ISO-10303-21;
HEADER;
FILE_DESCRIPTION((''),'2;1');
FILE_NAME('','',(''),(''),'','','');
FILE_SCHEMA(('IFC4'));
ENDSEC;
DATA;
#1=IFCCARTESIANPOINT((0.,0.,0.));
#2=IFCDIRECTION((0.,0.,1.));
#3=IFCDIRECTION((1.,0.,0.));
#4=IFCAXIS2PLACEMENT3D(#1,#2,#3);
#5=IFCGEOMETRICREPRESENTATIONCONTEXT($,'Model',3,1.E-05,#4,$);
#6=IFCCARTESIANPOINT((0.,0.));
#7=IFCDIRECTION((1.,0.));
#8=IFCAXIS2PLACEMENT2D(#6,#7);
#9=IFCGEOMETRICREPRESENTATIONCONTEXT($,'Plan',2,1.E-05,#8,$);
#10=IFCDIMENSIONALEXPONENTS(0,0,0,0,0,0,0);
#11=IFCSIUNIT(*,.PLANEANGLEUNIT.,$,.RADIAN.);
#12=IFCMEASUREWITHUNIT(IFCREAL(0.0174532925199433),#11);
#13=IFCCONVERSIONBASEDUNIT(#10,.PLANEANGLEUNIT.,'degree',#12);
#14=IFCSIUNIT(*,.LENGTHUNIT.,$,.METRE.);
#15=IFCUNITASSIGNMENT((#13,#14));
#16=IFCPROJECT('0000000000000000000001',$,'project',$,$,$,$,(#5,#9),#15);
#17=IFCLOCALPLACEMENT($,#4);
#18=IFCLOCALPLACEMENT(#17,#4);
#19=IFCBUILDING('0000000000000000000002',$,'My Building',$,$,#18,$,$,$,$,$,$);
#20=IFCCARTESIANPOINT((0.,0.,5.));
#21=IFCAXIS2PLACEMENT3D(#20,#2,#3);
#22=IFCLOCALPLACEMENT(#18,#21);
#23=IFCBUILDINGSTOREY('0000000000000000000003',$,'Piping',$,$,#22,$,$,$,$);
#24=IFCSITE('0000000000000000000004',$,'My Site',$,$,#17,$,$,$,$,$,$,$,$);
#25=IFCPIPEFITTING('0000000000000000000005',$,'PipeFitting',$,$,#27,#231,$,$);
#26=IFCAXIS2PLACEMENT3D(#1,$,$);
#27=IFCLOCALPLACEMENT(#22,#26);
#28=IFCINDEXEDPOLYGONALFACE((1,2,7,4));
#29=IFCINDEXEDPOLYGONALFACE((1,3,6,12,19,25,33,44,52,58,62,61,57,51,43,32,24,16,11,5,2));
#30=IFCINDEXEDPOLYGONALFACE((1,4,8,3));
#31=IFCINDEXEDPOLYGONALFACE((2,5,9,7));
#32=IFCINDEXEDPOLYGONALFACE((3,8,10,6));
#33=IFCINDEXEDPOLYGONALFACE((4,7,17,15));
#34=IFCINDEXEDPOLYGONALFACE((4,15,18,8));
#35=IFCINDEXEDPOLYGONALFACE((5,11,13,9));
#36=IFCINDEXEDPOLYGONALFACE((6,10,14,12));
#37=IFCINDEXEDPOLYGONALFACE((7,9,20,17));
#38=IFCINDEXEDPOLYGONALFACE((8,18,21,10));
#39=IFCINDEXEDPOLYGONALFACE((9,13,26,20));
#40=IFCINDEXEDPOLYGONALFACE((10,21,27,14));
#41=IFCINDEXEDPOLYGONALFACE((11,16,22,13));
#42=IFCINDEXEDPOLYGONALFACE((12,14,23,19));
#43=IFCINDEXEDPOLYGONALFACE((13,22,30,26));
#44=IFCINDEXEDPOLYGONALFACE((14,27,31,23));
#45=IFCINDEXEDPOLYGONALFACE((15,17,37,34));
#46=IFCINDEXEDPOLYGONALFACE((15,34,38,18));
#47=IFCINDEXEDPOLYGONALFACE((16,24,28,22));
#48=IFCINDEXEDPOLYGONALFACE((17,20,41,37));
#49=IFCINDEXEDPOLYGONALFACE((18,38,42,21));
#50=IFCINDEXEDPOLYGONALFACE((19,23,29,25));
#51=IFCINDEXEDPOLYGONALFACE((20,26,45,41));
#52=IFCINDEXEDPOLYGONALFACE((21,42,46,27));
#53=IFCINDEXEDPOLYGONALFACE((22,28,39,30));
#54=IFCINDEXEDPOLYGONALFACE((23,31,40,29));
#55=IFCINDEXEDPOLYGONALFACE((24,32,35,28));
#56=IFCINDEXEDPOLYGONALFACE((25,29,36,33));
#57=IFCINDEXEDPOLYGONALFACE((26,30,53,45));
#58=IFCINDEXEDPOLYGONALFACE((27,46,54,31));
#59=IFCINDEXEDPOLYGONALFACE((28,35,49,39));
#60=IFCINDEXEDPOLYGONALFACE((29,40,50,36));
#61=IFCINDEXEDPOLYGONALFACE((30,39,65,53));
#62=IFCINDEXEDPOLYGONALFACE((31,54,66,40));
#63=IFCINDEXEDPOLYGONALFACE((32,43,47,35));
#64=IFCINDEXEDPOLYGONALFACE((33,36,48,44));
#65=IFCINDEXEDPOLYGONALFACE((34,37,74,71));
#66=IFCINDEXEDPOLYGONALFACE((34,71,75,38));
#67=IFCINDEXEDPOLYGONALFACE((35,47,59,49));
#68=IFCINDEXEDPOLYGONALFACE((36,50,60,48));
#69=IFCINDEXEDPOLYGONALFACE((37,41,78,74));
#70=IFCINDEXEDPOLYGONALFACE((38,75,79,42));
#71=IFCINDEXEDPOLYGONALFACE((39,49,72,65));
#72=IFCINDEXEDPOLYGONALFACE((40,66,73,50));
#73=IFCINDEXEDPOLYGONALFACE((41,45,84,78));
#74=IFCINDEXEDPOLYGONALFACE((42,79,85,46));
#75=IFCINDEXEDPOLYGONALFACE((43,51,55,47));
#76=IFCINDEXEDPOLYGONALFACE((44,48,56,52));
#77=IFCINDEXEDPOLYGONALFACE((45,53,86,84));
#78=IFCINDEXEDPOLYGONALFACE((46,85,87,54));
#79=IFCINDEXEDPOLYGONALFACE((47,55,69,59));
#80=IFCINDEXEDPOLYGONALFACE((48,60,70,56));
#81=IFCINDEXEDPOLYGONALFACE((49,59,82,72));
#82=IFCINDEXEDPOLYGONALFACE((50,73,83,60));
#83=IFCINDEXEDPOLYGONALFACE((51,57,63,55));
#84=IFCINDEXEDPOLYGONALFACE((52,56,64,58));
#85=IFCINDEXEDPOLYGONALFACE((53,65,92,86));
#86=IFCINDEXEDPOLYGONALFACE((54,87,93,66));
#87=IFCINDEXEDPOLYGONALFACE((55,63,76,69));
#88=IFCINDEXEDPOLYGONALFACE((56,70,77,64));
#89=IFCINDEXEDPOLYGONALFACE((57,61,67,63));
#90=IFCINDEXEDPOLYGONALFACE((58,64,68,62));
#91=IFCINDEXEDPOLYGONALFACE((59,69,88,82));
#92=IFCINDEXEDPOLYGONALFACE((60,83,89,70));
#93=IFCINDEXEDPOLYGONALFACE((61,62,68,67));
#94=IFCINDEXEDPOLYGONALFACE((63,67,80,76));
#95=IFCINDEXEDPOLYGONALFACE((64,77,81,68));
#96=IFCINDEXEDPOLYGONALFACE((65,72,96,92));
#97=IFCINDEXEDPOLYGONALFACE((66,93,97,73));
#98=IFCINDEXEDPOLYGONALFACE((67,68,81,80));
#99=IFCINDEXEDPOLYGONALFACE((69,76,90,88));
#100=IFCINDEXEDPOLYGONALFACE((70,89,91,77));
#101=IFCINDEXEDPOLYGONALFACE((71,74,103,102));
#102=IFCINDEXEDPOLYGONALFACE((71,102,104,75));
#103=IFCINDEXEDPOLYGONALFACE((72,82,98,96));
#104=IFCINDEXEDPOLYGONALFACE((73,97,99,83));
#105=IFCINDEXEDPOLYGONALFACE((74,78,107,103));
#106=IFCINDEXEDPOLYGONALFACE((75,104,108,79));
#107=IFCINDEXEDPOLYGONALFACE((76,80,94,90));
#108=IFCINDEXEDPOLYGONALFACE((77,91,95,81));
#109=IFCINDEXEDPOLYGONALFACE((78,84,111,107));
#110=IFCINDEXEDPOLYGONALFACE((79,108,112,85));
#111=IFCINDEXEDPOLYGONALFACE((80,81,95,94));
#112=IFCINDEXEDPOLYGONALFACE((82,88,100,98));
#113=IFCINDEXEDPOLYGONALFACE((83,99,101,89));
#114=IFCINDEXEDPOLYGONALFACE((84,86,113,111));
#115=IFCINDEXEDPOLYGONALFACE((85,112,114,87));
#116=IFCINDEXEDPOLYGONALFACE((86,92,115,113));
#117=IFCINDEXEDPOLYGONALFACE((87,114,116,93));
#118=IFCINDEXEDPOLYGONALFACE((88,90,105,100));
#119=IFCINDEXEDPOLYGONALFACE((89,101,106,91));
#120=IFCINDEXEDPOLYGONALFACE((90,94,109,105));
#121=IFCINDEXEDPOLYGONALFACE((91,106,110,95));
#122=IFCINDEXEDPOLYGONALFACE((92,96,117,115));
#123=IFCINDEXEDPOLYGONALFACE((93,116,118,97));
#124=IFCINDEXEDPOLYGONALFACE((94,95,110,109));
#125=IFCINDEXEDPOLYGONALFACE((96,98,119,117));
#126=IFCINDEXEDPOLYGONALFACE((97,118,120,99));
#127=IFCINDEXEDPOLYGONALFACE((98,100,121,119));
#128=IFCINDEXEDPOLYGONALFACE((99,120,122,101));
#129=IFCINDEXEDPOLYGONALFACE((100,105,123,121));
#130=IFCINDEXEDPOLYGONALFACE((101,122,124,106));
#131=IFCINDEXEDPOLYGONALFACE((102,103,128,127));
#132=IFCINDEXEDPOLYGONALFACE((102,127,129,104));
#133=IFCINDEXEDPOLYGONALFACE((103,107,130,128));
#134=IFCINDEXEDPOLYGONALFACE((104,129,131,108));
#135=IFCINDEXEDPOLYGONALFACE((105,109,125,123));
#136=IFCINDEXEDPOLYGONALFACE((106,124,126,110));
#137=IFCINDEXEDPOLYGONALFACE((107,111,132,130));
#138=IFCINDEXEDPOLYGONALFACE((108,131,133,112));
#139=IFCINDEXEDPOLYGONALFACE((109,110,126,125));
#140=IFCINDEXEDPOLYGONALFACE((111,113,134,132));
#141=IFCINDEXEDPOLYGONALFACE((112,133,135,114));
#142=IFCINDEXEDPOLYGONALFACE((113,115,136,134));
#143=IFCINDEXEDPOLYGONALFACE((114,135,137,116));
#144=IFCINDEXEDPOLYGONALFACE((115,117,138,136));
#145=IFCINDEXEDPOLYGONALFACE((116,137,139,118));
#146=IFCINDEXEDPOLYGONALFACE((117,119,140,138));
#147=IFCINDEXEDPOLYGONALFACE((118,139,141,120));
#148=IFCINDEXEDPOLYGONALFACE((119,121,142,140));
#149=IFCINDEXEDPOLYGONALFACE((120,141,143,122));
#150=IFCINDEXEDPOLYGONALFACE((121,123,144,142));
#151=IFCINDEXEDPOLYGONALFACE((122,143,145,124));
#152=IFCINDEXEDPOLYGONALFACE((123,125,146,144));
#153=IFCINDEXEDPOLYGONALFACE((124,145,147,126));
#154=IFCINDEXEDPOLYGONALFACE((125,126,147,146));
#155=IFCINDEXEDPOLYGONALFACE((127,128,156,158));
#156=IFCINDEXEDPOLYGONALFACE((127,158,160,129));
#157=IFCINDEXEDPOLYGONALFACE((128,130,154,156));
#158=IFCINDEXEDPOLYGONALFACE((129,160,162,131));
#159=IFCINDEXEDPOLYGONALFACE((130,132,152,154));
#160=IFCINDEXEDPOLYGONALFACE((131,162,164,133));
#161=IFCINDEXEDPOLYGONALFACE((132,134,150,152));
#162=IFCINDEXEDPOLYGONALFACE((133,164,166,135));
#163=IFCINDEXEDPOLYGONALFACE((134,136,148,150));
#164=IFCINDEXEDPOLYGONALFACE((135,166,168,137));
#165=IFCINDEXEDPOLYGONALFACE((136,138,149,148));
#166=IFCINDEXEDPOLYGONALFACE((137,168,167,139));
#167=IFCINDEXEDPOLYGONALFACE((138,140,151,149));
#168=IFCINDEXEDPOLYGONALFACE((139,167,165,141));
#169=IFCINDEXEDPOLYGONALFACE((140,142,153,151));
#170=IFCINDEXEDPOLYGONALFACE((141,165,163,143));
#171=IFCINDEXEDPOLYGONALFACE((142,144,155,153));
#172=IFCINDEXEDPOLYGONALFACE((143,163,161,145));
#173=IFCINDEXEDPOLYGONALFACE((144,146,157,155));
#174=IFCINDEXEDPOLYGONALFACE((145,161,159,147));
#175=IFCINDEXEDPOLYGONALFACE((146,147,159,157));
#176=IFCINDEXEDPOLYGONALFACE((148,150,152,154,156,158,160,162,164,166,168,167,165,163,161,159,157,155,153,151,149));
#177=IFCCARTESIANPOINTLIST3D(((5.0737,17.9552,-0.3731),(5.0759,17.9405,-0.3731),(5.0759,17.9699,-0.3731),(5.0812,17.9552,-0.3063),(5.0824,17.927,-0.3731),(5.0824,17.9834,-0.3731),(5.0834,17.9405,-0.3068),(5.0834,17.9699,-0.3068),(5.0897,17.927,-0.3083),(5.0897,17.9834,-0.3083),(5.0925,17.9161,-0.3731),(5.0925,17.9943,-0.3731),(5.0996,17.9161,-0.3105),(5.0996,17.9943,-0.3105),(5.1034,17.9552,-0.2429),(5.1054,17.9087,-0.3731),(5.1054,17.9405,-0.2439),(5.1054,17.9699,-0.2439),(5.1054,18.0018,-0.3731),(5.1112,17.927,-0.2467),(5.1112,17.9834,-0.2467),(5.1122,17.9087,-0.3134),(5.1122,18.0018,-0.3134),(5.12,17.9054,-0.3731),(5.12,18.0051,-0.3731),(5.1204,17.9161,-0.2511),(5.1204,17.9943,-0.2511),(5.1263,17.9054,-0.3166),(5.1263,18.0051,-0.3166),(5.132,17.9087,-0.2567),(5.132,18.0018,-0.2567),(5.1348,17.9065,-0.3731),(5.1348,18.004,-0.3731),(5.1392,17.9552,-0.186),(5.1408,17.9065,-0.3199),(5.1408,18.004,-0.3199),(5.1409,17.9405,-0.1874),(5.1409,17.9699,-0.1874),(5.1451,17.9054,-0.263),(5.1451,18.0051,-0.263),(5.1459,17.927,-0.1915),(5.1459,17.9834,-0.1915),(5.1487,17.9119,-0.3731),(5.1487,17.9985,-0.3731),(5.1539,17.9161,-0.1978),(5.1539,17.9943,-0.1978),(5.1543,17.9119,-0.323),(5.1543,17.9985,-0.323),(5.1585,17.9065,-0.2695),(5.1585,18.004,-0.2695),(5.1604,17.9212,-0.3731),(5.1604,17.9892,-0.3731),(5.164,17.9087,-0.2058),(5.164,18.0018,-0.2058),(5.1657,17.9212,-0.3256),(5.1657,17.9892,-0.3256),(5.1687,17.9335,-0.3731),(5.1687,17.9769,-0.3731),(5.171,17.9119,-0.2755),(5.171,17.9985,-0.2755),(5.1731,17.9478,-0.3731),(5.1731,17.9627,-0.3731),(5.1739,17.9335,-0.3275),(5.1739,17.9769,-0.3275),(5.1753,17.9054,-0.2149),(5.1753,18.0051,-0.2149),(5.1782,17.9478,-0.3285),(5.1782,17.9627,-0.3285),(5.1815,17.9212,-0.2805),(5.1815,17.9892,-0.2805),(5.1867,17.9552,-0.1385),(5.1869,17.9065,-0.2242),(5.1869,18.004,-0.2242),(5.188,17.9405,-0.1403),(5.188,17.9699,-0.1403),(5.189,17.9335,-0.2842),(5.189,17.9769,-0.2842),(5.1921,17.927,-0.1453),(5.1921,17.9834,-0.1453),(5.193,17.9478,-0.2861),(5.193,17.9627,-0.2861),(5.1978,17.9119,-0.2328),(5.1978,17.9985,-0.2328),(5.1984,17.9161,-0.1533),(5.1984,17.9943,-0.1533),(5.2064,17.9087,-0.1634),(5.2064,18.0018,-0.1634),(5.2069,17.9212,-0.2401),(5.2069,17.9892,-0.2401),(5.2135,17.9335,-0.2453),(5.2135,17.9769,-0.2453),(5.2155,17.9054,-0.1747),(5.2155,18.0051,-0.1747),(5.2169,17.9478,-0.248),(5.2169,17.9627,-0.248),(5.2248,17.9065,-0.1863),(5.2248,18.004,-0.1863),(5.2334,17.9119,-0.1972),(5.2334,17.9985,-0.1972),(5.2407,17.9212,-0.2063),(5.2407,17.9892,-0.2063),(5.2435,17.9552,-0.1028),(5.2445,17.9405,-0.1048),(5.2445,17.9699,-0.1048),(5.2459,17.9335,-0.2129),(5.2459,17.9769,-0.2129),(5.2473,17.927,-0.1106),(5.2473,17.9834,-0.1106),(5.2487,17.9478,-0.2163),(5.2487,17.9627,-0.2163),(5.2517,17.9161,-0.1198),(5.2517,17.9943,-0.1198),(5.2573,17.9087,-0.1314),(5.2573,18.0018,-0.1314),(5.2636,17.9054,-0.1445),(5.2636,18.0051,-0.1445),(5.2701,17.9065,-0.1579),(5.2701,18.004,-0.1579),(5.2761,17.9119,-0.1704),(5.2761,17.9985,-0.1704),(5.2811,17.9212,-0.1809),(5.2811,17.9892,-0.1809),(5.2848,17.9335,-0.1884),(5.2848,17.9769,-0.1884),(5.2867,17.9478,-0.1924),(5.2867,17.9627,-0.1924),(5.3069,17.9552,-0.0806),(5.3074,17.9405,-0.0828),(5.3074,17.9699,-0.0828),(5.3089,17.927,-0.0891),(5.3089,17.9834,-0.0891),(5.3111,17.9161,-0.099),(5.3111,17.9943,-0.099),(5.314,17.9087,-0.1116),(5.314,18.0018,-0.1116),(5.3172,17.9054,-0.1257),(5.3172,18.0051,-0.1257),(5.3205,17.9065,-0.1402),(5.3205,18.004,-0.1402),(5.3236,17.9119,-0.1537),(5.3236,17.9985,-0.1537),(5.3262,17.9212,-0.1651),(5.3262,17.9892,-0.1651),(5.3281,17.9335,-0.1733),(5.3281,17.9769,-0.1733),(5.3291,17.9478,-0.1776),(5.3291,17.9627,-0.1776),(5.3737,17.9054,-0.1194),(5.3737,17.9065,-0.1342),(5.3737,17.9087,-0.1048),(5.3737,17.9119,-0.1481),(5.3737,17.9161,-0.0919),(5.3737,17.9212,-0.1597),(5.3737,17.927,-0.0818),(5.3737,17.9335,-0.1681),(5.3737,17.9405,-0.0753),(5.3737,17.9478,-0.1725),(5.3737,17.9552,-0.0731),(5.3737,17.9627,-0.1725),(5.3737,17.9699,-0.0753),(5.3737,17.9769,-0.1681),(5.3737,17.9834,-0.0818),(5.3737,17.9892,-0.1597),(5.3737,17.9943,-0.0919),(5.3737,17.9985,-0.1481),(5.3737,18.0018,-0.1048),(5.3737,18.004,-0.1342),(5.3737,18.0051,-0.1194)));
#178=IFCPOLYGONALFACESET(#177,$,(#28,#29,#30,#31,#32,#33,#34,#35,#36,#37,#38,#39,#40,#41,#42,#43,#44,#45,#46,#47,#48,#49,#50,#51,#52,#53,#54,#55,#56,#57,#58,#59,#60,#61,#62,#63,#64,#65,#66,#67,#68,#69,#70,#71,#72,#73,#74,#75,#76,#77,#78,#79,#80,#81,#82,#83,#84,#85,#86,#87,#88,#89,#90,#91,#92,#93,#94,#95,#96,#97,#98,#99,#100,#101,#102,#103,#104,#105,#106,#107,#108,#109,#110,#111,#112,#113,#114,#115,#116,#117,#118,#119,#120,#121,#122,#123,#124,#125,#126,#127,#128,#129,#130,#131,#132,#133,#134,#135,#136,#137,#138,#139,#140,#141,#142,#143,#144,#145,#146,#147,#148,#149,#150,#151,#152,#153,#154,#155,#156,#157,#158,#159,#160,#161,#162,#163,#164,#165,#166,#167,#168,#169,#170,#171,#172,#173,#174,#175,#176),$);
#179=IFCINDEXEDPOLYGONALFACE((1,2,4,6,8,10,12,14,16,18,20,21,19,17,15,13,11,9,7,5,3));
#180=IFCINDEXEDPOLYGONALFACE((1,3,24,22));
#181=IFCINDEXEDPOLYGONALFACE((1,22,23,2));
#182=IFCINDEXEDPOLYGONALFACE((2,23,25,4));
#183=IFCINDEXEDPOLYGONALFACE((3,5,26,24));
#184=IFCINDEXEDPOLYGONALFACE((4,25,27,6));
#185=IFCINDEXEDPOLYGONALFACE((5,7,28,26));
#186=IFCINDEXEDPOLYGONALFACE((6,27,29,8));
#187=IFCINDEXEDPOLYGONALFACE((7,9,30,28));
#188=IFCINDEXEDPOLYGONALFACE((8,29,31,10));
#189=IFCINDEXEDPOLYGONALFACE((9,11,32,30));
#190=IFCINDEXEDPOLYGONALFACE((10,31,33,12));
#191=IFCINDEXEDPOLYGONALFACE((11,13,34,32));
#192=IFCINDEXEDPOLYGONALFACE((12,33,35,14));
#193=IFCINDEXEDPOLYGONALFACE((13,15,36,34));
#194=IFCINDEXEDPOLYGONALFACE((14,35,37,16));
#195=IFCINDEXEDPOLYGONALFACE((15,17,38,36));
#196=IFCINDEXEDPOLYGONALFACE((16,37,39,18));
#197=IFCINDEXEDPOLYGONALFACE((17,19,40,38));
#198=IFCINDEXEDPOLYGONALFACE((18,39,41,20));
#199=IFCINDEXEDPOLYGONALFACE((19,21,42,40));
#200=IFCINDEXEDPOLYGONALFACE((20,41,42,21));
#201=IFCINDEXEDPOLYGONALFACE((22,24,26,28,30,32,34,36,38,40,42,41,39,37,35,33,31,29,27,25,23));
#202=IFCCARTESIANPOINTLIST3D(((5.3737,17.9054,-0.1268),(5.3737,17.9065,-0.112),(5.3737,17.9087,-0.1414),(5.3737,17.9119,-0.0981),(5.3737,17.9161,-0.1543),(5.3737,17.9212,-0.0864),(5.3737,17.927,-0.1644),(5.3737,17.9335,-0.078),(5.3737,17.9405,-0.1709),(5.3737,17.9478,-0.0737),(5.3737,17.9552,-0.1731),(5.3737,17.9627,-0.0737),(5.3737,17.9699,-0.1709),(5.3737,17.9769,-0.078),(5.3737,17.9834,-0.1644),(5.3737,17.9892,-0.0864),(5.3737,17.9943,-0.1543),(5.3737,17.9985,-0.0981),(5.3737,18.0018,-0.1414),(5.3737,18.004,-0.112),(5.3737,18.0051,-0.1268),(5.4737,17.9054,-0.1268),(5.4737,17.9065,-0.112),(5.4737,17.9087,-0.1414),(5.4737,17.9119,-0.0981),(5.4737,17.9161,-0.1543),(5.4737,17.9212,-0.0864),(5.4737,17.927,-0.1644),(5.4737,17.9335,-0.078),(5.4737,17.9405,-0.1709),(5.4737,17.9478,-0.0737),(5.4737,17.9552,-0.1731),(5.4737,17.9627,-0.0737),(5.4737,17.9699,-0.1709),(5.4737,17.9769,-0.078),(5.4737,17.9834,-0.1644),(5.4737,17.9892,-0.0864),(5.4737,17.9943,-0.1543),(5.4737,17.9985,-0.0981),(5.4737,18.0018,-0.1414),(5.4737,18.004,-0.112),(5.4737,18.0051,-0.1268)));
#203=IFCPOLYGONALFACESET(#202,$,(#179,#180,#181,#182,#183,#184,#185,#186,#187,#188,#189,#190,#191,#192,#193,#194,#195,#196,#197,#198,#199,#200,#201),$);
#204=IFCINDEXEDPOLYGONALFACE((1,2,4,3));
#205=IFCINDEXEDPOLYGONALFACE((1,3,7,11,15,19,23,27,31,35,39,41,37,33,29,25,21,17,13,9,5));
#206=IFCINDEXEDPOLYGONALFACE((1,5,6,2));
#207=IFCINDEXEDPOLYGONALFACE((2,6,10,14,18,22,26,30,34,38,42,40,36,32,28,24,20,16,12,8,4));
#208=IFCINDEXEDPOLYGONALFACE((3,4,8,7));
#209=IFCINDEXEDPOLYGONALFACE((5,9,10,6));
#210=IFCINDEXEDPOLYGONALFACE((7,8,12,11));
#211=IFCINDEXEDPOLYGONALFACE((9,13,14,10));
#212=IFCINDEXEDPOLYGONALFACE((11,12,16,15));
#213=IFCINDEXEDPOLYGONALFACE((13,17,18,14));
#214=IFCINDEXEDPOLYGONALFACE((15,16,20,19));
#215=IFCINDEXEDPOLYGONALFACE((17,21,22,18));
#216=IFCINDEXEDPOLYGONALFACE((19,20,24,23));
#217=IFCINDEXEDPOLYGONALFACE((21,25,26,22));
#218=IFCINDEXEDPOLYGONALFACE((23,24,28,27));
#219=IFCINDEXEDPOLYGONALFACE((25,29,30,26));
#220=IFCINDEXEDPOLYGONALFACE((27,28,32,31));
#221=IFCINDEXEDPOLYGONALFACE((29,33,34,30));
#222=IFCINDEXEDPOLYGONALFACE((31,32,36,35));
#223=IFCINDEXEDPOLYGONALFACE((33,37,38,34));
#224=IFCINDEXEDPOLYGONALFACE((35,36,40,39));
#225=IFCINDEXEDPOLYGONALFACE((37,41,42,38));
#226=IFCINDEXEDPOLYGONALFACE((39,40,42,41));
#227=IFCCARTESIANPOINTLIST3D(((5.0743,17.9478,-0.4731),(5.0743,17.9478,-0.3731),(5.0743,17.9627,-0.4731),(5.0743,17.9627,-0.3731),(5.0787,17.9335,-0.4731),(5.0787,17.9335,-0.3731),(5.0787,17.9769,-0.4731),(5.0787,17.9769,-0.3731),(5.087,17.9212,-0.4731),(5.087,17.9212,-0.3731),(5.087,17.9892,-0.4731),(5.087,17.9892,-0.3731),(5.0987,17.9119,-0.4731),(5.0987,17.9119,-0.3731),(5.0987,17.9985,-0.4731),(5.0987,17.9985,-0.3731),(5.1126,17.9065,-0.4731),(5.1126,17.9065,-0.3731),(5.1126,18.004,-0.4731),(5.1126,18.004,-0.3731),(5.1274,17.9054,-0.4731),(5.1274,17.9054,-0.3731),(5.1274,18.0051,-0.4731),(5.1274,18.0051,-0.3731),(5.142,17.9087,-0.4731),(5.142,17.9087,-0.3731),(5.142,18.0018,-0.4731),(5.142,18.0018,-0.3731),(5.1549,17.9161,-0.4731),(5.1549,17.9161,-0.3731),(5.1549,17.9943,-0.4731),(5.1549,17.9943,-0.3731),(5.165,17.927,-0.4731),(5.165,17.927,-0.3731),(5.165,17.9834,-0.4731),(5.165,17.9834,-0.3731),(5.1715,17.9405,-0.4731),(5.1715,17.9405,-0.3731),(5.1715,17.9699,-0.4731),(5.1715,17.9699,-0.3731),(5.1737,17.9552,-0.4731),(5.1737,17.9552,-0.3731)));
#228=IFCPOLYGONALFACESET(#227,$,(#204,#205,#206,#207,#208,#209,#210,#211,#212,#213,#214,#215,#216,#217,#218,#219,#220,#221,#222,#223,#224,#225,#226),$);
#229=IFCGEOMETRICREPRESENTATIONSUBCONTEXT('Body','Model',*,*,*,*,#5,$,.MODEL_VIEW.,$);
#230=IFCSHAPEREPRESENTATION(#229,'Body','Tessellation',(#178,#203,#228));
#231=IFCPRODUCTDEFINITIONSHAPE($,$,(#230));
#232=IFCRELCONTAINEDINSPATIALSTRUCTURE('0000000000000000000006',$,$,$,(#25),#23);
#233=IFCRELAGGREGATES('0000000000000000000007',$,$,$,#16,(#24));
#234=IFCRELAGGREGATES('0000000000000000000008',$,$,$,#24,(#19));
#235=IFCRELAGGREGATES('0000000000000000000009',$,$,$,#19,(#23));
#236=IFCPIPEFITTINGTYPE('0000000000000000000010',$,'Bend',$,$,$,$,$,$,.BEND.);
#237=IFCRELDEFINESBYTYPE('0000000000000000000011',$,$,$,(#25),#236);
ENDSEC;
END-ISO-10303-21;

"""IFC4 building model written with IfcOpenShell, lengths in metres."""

from ifc_helpers import new_model, entity, si_unit, converted_unit, frame, origin_with_axes, origin_2d_with_axis, place, context, subcontext, project, spatial, circle, extrude, source, transform, mapped, type_object, type_shapes, element, save


model = new_model("IFC4")

# Units and contexts
model_context = context("Model", 3, precision=1e-05, world=origin_with_axes())
plan_context = context("Plan", 2, precision=1e-05, world=origin_2d_with_axis())
body_context = subcontext(model_context, "Body", "Model", "MODEL_VIEW")
ifc_project = project(units=[converted_unit("PLANEANGLEUNIT", "degree", entity("IfcReal", 0.0174532925199433), si_unit("PLANEANGLEUNIT", "RADIAN"), dimensions=[0, 0, 0, 0, 0, 0, 0]), si_unit("LENGTHUNIT", "METRE")], contexts=[model_context, plan_context])

# Site, building, storey
site_placement = place(None, origin_with_axes())
site = spatial("IfcSite", under=ifc_project, at=site_placement, Name="My Site")
building_placement = place(site_placement, origin_with_axes())
building = spatial("IfcBuilding", under=site, at=building_placement, Name="My Building")
storey_placement = place(building_placement, frame((0.0, 0.0, 5.0), z_axis=(0.0, 0.0, 1.0), x_axis=(1.0, 0.0, 0.0)))
storey = spatial("IfcBuildingStorey", under=building, at=storey_placement, Name="Piping")

# Pipe fitting
pipe_fitting_type_1 = type_object("IfcPipeFittingType", Name="Bend", PredefinedType="BEND")
shared_shape = source(origin_with_axes(), body_context, "Body", "SolidModel", [
    entity("IfcSweptDiskSolid", entity("IfcIndexedPolyCurve", entity("IfcCartesianPointList3D", [[0.0, 0.0, -0.1], [0.0732, 0.0, -0.2768], [0.25, 0.0, -0.35]]), [entity("IfcArcIndex", [1, 2, 3])]), 0.05),
    extrude(circle(Radius=0.05), origin_with_axes(), (0.0, 0.0, -1.0), 0.1),
    extrude(circle(Radius=0.05), frame((0.25, 0.0, -0.35), z_axis=(1.0, 0.0, 0.0), x_axis=(0.0, 0.0, 1.0)), (0.0, 0.0, 1.0), 0.1),
])
type_shapes(pipe_fitting_type_1, [shared_shape])
for number, where, z_axis, x_axis, name in (
    (1, (5.4737, 17.9552, -0.1231), (1.0, 0.000001, 0.0), (0.0, 0.0, -1.0), "PipeFitting"),
):
    element("IfcPipeFitting", number, at=place(storey_placement, frame(where, z_axis=z_axis, x_axis=x_axis)), inside=storey, type_object=pipe_fitting_type_1, Name=name, context=body_context, shape_type="MappedRepresentation", body=[
        mapped(shared_shape, transform((0.0, 0.0, 0.0), x_axis=(1.0, 0.0, 0.0), y_axis=(0.0, 1.0, 0.0), z_axis=(0.0, 0.0, 1.0), scale=1.0)),
    ])

save(model, "model.ifc")
